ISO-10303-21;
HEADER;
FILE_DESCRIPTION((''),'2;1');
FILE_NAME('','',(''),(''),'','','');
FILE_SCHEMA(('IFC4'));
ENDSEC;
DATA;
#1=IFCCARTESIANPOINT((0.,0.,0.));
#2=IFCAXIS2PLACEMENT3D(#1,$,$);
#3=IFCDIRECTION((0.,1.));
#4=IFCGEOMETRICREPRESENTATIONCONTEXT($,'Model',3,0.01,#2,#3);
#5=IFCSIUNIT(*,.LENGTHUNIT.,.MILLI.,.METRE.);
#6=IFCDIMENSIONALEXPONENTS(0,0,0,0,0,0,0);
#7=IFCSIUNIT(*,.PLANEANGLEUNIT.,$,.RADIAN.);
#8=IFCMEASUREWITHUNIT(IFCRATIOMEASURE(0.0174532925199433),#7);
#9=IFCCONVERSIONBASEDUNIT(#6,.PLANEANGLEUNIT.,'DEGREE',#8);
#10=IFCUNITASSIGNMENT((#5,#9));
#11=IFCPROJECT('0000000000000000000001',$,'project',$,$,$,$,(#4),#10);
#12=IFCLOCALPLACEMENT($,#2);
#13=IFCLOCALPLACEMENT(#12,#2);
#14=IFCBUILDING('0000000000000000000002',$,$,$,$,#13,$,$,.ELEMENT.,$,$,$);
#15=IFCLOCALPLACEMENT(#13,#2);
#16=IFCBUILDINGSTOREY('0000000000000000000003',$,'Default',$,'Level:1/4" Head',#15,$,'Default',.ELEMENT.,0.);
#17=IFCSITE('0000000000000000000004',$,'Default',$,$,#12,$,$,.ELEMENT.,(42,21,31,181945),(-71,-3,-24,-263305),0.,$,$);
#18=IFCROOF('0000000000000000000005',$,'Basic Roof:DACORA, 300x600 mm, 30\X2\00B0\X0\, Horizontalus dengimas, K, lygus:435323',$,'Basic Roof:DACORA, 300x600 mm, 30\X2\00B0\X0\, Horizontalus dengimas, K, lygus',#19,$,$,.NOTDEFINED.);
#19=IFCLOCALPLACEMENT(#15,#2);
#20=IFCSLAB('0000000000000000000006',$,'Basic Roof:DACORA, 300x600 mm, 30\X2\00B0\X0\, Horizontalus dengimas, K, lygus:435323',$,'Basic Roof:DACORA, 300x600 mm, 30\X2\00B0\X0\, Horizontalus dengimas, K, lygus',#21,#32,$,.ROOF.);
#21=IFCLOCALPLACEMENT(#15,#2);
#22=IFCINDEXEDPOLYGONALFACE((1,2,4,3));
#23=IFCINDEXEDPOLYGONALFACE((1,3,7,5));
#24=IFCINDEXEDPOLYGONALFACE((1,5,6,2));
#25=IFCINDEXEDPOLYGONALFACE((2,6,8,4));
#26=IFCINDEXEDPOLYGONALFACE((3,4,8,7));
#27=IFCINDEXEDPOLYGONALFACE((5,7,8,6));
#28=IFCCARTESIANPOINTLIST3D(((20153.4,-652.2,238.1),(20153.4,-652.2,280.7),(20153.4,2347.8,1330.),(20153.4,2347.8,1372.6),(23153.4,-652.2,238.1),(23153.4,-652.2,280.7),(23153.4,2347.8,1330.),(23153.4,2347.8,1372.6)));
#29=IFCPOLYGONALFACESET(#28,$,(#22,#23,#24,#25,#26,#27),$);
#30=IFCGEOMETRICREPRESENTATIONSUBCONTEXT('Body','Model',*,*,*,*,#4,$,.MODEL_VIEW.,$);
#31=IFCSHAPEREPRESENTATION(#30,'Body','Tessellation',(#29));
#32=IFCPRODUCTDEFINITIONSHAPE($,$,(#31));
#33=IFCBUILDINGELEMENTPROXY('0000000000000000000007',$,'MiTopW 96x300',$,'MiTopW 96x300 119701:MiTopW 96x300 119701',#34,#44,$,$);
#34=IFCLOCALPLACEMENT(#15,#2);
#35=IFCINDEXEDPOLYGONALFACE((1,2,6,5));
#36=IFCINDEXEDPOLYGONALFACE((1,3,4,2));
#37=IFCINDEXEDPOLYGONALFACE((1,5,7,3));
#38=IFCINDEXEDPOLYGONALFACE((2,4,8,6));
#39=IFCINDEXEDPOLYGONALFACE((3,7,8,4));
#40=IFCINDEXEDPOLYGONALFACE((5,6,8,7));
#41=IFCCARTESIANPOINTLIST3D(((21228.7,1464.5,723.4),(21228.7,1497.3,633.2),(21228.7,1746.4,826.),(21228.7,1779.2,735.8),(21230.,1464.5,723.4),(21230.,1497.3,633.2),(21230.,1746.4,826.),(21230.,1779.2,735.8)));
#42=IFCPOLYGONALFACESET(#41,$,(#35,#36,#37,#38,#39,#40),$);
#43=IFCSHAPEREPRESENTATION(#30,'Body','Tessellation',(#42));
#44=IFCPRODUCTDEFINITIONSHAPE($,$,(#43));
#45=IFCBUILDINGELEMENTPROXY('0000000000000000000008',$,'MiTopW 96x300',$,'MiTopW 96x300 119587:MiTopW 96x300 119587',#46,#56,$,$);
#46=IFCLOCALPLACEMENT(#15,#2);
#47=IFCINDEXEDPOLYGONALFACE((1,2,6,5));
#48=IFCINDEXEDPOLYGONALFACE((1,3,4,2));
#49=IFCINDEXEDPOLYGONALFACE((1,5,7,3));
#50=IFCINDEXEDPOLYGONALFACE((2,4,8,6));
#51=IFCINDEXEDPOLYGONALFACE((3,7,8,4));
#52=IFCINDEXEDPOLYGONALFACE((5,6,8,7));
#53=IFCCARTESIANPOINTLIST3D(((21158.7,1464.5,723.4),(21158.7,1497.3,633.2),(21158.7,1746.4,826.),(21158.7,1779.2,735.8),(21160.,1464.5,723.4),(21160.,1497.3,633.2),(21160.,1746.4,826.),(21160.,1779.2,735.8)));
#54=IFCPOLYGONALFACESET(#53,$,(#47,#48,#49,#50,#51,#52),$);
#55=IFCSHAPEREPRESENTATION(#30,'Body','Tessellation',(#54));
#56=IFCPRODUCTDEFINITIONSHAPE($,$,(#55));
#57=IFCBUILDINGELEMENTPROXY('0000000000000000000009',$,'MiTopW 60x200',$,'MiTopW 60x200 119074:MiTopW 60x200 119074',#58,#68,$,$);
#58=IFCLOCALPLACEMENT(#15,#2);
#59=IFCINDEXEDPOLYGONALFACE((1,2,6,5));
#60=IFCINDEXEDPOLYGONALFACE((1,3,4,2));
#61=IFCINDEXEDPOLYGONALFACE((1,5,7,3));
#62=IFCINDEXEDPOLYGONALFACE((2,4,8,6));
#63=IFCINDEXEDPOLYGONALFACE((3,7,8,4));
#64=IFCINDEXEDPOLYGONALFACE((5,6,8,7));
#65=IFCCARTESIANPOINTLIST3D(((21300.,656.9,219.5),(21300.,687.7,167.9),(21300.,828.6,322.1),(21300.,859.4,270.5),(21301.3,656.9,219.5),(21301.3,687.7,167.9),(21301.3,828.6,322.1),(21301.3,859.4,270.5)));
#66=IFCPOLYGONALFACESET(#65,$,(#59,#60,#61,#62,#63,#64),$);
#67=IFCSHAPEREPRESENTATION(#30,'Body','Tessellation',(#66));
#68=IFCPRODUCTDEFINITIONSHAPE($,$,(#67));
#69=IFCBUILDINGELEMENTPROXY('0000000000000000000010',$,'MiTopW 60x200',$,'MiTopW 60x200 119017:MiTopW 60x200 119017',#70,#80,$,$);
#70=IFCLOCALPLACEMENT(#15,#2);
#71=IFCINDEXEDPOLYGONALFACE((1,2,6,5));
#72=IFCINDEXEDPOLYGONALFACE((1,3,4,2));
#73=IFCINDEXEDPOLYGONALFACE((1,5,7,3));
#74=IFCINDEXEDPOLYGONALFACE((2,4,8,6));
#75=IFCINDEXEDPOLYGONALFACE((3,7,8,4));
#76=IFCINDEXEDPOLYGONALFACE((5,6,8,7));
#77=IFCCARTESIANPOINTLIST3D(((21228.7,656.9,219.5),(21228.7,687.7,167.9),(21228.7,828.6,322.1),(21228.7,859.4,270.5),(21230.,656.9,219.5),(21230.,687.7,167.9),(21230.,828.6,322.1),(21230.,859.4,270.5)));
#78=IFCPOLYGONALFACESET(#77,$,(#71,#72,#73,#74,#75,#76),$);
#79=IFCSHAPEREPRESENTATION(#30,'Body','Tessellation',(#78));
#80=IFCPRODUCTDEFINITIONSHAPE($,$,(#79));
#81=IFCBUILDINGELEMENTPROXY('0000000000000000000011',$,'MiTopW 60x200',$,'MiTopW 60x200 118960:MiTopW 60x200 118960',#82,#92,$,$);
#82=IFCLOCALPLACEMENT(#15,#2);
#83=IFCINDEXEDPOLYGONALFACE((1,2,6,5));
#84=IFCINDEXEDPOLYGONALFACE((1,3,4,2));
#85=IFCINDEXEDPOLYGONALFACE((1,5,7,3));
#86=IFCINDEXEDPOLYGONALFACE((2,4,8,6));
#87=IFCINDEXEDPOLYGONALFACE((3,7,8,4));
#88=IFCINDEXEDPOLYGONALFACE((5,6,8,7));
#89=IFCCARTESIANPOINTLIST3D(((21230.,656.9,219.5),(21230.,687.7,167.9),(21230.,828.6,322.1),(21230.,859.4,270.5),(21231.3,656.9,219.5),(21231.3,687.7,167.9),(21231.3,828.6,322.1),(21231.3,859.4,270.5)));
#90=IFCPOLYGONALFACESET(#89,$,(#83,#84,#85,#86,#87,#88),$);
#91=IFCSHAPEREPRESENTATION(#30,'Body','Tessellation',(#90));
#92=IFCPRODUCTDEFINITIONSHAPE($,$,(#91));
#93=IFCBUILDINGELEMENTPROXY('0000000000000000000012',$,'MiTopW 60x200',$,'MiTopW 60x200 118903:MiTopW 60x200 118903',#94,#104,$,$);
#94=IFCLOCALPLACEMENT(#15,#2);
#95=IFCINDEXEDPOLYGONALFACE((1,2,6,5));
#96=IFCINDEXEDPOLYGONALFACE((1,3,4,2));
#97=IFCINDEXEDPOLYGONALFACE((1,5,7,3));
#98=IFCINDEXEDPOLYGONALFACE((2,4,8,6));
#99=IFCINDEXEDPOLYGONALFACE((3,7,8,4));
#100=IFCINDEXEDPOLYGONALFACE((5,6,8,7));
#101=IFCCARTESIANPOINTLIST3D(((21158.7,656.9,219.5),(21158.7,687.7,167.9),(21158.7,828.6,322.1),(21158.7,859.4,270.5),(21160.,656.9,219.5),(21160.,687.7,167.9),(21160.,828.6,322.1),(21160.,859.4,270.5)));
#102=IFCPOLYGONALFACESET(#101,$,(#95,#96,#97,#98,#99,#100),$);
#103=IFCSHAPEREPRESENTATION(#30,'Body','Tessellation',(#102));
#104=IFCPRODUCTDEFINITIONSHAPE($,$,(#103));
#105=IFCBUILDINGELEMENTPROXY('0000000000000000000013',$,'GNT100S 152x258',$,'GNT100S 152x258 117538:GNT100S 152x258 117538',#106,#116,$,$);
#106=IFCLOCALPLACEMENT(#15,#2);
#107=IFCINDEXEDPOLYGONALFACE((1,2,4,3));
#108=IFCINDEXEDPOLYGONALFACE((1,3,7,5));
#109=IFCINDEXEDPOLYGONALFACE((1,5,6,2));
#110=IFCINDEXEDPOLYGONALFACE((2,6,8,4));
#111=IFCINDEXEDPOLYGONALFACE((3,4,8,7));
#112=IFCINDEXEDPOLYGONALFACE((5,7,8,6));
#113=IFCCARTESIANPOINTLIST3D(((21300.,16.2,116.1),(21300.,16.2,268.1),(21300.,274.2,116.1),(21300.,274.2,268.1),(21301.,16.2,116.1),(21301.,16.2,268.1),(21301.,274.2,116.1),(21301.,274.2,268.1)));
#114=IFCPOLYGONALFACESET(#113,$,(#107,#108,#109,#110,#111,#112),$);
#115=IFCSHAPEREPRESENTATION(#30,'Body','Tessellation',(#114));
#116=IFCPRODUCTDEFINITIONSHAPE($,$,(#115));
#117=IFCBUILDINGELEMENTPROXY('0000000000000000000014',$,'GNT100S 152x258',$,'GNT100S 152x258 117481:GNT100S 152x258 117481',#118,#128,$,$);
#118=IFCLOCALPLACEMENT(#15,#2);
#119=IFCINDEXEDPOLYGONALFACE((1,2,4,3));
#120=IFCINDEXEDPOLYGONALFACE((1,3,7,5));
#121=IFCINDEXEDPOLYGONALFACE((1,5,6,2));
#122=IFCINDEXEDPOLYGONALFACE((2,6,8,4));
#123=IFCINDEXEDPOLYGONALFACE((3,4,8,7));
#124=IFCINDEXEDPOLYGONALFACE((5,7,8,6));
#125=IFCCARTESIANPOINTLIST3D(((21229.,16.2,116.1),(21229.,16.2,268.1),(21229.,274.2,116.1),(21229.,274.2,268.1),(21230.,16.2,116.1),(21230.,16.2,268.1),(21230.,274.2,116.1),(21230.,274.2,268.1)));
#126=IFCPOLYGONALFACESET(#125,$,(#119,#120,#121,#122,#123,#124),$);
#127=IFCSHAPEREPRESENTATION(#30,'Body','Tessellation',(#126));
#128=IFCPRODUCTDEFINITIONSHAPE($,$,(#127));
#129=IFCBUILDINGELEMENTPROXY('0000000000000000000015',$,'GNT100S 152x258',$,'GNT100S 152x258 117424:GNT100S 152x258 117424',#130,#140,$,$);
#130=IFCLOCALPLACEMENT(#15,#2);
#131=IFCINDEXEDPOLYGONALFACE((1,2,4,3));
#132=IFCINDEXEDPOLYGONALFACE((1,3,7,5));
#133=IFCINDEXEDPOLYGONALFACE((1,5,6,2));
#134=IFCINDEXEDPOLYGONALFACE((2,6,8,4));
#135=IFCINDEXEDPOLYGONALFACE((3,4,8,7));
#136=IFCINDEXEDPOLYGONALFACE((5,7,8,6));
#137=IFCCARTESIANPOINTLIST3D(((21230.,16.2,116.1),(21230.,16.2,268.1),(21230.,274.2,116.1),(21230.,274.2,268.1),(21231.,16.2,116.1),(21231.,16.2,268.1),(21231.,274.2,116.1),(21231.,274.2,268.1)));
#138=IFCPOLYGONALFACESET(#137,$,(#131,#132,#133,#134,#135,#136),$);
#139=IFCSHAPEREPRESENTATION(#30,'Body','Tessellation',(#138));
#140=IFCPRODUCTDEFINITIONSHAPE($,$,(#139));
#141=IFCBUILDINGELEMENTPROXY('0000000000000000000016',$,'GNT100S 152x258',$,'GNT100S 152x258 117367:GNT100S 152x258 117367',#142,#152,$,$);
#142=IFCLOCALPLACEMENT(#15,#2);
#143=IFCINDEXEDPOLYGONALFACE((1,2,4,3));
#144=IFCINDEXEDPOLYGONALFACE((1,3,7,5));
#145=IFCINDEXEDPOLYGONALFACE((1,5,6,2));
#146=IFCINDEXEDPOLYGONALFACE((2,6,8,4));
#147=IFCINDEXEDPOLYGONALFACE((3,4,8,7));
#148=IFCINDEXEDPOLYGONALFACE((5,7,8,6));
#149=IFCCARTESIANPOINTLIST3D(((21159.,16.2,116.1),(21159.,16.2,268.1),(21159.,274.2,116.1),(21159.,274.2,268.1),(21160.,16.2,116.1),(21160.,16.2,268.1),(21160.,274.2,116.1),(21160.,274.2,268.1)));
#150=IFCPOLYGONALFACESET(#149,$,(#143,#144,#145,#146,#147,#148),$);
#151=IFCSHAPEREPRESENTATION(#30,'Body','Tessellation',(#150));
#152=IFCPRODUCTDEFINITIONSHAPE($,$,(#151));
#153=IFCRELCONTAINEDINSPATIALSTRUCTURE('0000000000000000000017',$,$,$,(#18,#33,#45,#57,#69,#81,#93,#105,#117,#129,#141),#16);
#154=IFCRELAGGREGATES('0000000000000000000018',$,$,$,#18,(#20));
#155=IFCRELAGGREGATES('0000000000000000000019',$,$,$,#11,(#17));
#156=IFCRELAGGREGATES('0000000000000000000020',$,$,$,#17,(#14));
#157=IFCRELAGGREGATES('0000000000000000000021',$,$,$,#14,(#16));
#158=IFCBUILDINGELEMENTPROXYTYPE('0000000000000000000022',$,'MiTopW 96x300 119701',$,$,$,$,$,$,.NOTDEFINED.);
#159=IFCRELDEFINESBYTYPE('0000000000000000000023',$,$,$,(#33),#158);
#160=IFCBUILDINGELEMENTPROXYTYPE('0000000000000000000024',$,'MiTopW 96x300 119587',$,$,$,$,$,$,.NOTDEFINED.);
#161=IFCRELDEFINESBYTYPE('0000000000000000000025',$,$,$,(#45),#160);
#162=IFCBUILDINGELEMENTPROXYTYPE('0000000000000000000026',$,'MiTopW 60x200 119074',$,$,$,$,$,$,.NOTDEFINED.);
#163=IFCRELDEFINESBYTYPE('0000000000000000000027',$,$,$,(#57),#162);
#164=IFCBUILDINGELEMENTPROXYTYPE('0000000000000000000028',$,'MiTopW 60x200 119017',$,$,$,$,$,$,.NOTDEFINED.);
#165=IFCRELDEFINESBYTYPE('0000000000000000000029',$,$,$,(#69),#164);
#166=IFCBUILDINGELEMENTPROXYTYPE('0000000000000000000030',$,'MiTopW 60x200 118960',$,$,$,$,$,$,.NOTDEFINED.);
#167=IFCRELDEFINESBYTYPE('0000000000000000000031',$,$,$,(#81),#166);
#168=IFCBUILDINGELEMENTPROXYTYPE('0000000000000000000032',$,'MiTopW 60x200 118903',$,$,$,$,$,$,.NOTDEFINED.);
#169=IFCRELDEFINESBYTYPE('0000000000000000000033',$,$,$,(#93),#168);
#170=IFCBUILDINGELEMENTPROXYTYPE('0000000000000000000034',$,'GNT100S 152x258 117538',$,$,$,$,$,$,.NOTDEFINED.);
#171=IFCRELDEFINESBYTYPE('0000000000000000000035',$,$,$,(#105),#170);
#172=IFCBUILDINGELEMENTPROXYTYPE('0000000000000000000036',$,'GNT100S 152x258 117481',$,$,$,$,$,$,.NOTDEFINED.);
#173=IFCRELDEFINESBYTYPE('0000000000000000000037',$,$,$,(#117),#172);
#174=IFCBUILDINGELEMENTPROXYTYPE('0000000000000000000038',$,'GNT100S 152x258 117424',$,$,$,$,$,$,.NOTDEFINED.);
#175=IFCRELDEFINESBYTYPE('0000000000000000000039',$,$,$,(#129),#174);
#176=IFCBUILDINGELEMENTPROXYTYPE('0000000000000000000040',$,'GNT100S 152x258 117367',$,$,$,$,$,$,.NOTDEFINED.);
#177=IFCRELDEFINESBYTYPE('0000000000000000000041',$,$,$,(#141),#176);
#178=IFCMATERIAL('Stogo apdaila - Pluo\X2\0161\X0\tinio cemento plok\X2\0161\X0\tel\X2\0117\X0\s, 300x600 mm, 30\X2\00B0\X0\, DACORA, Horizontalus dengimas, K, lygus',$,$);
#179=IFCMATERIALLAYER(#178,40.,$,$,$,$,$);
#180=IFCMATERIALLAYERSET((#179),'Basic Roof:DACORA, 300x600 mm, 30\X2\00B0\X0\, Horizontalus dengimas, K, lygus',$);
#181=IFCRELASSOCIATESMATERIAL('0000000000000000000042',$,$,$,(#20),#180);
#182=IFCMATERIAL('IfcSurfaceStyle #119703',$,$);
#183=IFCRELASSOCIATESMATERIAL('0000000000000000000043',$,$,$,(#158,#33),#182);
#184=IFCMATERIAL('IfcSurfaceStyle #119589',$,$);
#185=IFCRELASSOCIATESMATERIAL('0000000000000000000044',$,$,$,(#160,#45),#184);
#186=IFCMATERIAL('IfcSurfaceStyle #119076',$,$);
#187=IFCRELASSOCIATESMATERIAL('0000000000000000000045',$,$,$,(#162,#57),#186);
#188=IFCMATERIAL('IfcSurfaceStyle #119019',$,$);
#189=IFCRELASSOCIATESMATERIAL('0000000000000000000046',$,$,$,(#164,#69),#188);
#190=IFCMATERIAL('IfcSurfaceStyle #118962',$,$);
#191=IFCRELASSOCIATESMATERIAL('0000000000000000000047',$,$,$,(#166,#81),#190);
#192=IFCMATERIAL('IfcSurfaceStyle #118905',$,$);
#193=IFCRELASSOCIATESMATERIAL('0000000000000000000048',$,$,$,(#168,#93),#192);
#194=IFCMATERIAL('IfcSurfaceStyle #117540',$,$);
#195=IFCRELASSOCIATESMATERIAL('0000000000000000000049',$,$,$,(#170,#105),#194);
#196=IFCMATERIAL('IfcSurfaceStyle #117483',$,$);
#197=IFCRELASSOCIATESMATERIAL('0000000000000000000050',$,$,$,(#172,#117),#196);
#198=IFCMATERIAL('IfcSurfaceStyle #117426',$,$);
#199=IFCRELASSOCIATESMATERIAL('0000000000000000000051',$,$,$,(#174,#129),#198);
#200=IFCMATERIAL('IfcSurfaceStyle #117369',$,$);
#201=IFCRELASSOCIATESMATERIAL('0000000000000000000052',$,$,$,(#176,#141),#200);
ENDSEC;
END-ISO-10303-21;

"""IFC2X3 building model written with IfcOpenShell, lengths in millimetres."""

from ifc_helpers import new_model, entity, si_unit, converted_unit, direction, frame, frame_2d, origin, origin_2d_with_axis, place, context, subcontext, project, spatial, polyline, rectangle, outline, extrude, source, transform, mapped, material, layer, layer_set, type_object, type_shapes, element, aggregate, save


model = new_model("IFC2X3")

# Units and contexts
model_context = context("Model", 3, precision=0.01, world=origin(), true_north=direction((0.0, 1.0)))
body_context = subcontext(model_context, "Body", "Model", "MODEL_VIEW")
ifc_project = project(units=[si_unit("LENGTHUNIT", "METRE", prefix="MILLI"), converted_unit("PLANEANGLEUNIT", "DEGREE", entity("IfcRatioMeasure", 0.0174532925199433), si_unit("PLANEANGLEUNIT", "RADIAN"), dimensions=[0, 0, 0, 0, 0, 0, 0])], contexts=[model_context])

# Site, building, storey
site_placement = place(None, origin())
site = spatial("IfcSite", under=ifc_project, at=site_placement, Name="Default", CompositionType="ELEMENT", RefLatitude=(42, 21, 31, 181945), RefLongitude=(-71, -3, -24, -263305), RefElevation=0.0)
building_placement = place(site_placement, origin())
building = spatial("IfcBuilding", under=site, at=building_placement, CompositionType="ELEMENT")
storey_placement = place(building_placement, origin())
storey = spatial("IfcBuildingStorey", under=building, at=storey_placement, Name="Default", ObjectType="Level:1/4\" Head", LongName="Default", CompositionType="ELEMENT", Elevation=0.0)

# Roof, slab
roof_placement = place(storey_placement, frame((20153.4, -652.2, 238.1)))
roof = element("IfcRoof", 1, at=roof_placement, inside=storey, Name="Basic Roof:DACORA, 300x600 mm, 30°, Horizontalus dengimas, K, lygus:435323", ObjectType="Basic Roof:DACORA, 300x600 mm, 30°, Horizontalus dengimas, K, lygus", ShapeType="NOTDEFINED")
ifc_material_1 = material(Name="Stogo apdaila - Pluoštinio cemento plokštelės, 300x600 mm, 30°, DACORA, Horizontalus dengimas, K, lygus")
ifc_layer = layer(ifc_material_1, 40.0)
ifc_layer_set = layer_set([ifc_layer], Name="Basic Roof:DACORA, 300x600 mm, 30°, Horizontalus dengimas, K, lygus")
slab_placement = place(roof_placement, origin())
slab = element("IfcSlab", 2, at=slab_placement, material=ifc_layer_set, Name="Basic Roof:DACORA, 300x600 mm, 30°, Horizontalus dengimas, K, lygus:435323", ObjectType="Basic Roof:DACORA, 300x600 mm, 30°, Horizontalus dengimas, K, lygus", PredefinedType="ROOF", context=body_context, shape_type="SweptSolid", body=[
    extrude(rectangle(XDim=3192.5, YDim=3000.0, at=frame_2d((0.0, 0.0), x_axis=(0.0, -1.0))), frame((1500.0, 1500.0, 546.0), z_axis=(0.0, -0.34202, 0.939693), x_axis=(1.0, 0.0, 0.0)), (0.0, 0.34202, 0.939693), 42.6),
])
aggregate(roof, [slab])

# Building element proxies
ifc_material_2 = material(Name="IfcSurfaceStyle #119703")
building_element_proxy_type_1 = type_object("IfcBuildingElementProxyType", Name="MiTopW 96x300 119701", PredefinedType="NOTDEFINED", material=ifc_material_2)
shared_shape_1 = source(origin(), body_context, "Body", "SweptSolid", [
    extrude(outline(polyline([(-150.0, -48.0), (150.0, -48.0), (150.0, 48.0), (-150.0, 48.0), (-150.0, -48.0)])), frame((150.0, 48.0, 0.0), z_axis=(0.0, 0.0, 1.0), x_axis=(-1.0, 0.0, 0.0)), (0.0, 0.0, 1.0), 1.3),
])
type_shapes(building_element_proxy_type_1, [shared_shape_1])
proxy_1_placement = place(building_placement, frame((21230.0, 1464.5, 723.4), z_axis=(-1.0, 0.0, 0.0), x_axis=(0.0, 0.939693, 0.34202)))
element("IfcBuildingElementProxy", 3, at=proxy_1_placement, inside=storey, type_object=building_element_proxy_type_1, material=ifc_material_2, Name="MiTopW 96x300", ObjectType="MiTopW 96x300 119701:MiTopW 96x300 119701", context=body_context, shape_type="MappedRepresentation", body=[
    mapped(shared_shape_1, transform((0.0, 0.0, 0.0), scale=1.0)),
])
ifc_material_3 = material(Name="IfcSurfaceStyle #119589")
building_element_proxy_type_2 = type_object("IfcBuildingElementProxyType", Name="MiTopW 96x300 119587", PredefinedType="NOTDEFINED", material=ifc_material_3)
shared_shape_2 = source(origin(), body_context, "Body", "SweptSolid", [
    extrude(outline(polyline([(-150.0, -48.0), (150.0, -48.0), (150.0, 48.0), (-150.0, 48.0), (-150.0, -48.0)])), frame((150.0, 48.0, 0.0), z_axis=(0.0, 0.0, 1.0), x_axis=(-1.0, 0.0, 0.0)), (0.0, 0.0, 1.0), 1.3),
])
type_shapes(building_element_proxy_type_2, [shared_shape_2])
proxy_2_placement = place(building_placement, frame((21160.0, 1464.5, 723.4), z_axis=(-1.0, 0.0, 0.0), x_axis=(0.0, 0.939693, 0.34202)))
element("IfcBuildingElementProxy", 4, at=proxy_2_placement, inside=storey, type_object=building_element_proxy_type_2, material=ifc_material_3, Name="MiTopW 96x300", ObjectType="MiTopW 96x300 119587:MiTopW 96x300 119587", context=body_context, shape_type="MappedRepresentation", body=[
    mapped(shared_shape_2, transform((0.0, 0.0, 0.0), scale=1.0)),
])
ifc_material_4 = material(Name="IfcSurfaceStyle #119076")
building_element_proxy_type_3 = type_object("IfcBuildingElementProxyType", Name="MiTopW 60x200 119074", PredefinedType="NOTDEFINED", material=ifc_material_4)
shared_shape_3 = source(origin(), body_context, "Body", "SweptSolid", [
    extrude(outline(polyline([(-100.0, -30.0), (100.0, -30.0), (100.0, 30.0), (-100.0, 30.0), (-100.0, -30.0)])), frame((100.0, 30.0, 0.0), z_axis=(0.0, 0.0, 1.0), x_axis=(-1.0, 0.0, 0.0)), (0.0, 0.0, 1.0), 1.3),
])
type_shapes(building_element_proxy_type_3, [shared_shape_3])
proxy_3_placement = place(building_placement, frame((21301.3, 656.9, 219.5), z_axis=(-1.0, 0.0, 0.0), x_axis=(0.0, 0.858392, 0.512994)))
element("IfcBuildingElementProxy", 5, at=proxy_3_placement, inside=storey, type_object=building_element_proxy_type_3, material=ifc_material_4, Name="MiTopW 60x200", ObjectType="MiTopW 60x200 119074:MiTopW 60x200 119074", context=body_context, shape_type="MappedRepresentation", body=[
    mapped(shared_shape_3, transform((0.0, 0.0, 0.0), scale=1.0)),
])
ifc_material_5 = material(Name="IfcSurfaceStyle #119019")
building_element_proxy_type_4 = type_object("IfcBuildingElementProxyType", Name="MiTopW 60x200 119017", PredefinedType="NOTDEFINED", material=ifc_material_5)
shared_shape_4 = source(origin(), body_context, "Body", "SweptSolid", [
    extrude(outline(polyline([(-100.0, -30.0), (100.0, -30.0), (100.0, 30.0), (-100.0, 30.0), (-100.0, -30.0)])), frame((100.0, 30.0, 0.0), z_axis=(0.0, 0.0, 1.0), x_axis=(-1.0, 0.0, 0.0)), (0.0, 0.0, 1.0), 1.3),
])
type_shapes(building_element_proxy_type_4, [shared_shape_4])
proxy_4_placement = place(building_placement, frame((21230.0, 656.9, 219.5), z_axis=(-1.0, 0.0, 0.0), x_axis=(0.0, 0.858392, 0.512994)))
element("IfcBuildingElementProxy", 6, at=proxy_4_placement, inside=storey, type_object=building_element_proxy_type_4, material=ifc_material_5, Name="MiTopW 60x200", ObjectType="MiTopW 60x200 119017:MiTopW 60x200 119017", context=body_context, shape_type="MappedRepresentation", body=[
    mapped(shared_shape_4, transform((0.0, 0.0, 0.0), scale=1.0)),
])
ifc_material_6 = material(Name="IfcSurfaceStyle #118962")
building_element_proxy_type_5 = type_object("IfcBuildingElementProxyType", Name="MiTopW 60x200 118960", PredefinedType="NOTDEFINED", material=ifc_material_6)
shared_shape_5 = source(origin(), body_context, "Body", "SweptSolid", [
    extrude(outline(polyline([(-100.0, -30.0), (100.0, -30.0), (100.0, 30.0), (-100.0, 30.0), (-100.0, -30.0)])), frame((100.0, 30.0, 0.0), z_axis=(0.0, 0.0, 1.0), x_axis=(-1.0, 0.0, 0.0)), (0.0, 0.0, 1.0), 1.3),
])
type_shapes(building_element_proxy_type_5, [shared_shape_5])
proxy_5_placement = place(building_placement, frame((21231.3, 656.9, 219.5), z_axis=(-1.0, 0.0, 0.0), x_axis=(0.0, 0.858392, 0.512994)))
element("IfcBuildingElementProxy", 7, at=proxy_5_placement, inside=storey, type_object=building_element_proxy_type_5, material=ifc_material_6, Name="MiTopW 60x200", ObjectType="MiTopW 60x200 118960:MiTopW 60x200 118960", context=body_context, shape_type="MappedRepresentation", body=[
    mapped(shared_shape_5, transform((0.0, 0.0, 0.0), scale=1.0)),
])
ifc_material_7 = material(Name="IfcSurfaceStyle #118905")
building_element_proxy_type_6 = type_object("IfcBuildingElementProxyType", Name="MiTopW 60x200 118903", PredefinedType="NOTDEFINED", material=ifc_material_7)
shared_shape_6 = source(origin(), body_context, "Body", "SweptSolid", [
    extrude(outline(polyline([(-100.0, -30.0), (100.0, -30.0), (100.0, 30.0), (-100.0, 30.0), (-100.0, -30.0)])), frame((100.0, 30.0, 0.0), z_axis=(0.0, 0.0, 1.0), x_axis=(-1.0, 0.0, 0.0)), (0.0, 0.0, 1.0), 1.3),
])
type_shapes(building_element_proxy_type_6, [shared_shape_6])
proxy_6_placement = place(building_placement, frame((21160.0, 656.9, 219.5), z_axis=(-1.0, 0.0, 0.0), x_axis=(0.0, 0.858392, 0.512994)))
element("IfcBuildingElementProxy", 8, at=proxy_6_placement, inside=storey, type_object=building_element_proxy_type_6, material=ifc_material_7, Name="MiTopW 60x200", ObjectType="MiTopW 60x200 118903:MiTopW 60x200 118903", context=body_context, shape_type="MappedRepresentation", body=[
    mapped(shared_shape_6, transform((0.0, 0.0, 0.0), scale=1.0)),
])
ifc_material_8 = material(Name="IfcSurfaceStyle #117540")
building_element_proxy_type_7 = type_object("IfcBuildingElementProxyType", Name="GNT100S 152x258 117538", PredefinedType="NOTDEFINED", material=ifc_material_8)
shared_shape_7 = source(origin(), body_context, "Body", "SweptSolid", [
    extrude(rectangle(XDim=258.0, YDim=152.0, at=origin_2d_with_axis()), frame((129.0, 76.0, 0.0), z_axis=(0.0, 0.0, 1.0), x_axis=(-1.0, 0.0, 0.0)), (0.0, 0.0, 1.0), 1.0),
])
type_shapes(building_element_proxy_type_7, [shared_shape_7])
proxy_7_placement = place(building_placement, frame((21301.0, 16.2, 268.1), z_axis=(-1.0, 0.0, 0.0), x_axis=(0.0, 1.0, 0.0)))
element("IfcBuildingElementProxy", 9, at=proxy_7_placement, inside=storey, type_object=building_element_proxy_type_7, material=ifc_material_8, Name="GNT100S 152x258", ObjectType="GNT100S 152x258 117538:GNT100S 152x258 117538", context=body_context, shape_type="MappedRepresentation", body=[
    mapped(shared_shape_7, transform((0.0, 0.0, 0.0), scale=1.0)),
])
ifc_material_9 = material(Name="IfcSurfaceStyle #117483")
building_element_proxy_type_8 = type_object("IfcBuildingElementProxyType", Name="GNT100S 152x258 117481", PredefinedType="NOTDEFINED", material=ifc_material_9)
shared_shape_8 = source(origin(), body_context, "Body", "SweptSolid", [
    extrude(rectangle(XDim=258.0, YDim=152.0, at=origin_2d_with_axis()), frame((129.0, 76.0, 0.0), z_axis=(0.0, 0.0, 1.0), x_axis=(-1.0, 0.0, 0.0)), (0.0, 0.0, 1.0), 1.0),
])
type_shapes(building_element_proxy_type_8, [shared_shape_8])
proxy_8_placement = place(building_placement, frame((21230.0, 16.2, 268.1), z_axis=(-1.0, 0.0, 0.0), x_axis=(0.0, 1.0, 0.0)))
element("IfcBuildingElementProxy", 10, at=proxy_8_placement, inside=storey, type_object=building_element_proxy_type_8, material=ifc_material_9, Name="GNT100S 152x258", ObjectType="GNT100S 152x258 117481:GNT100S 152x258 117481", context=body_context, shape_type="MappedRepresentation", body=[
    mapped(shared_shape_8, transform((0.0, 0.0, 0.0), scale=1.0)),
])
ifc_material_10 = material(Name="IfcSurfaceStyle #117426")
building_element_proxy_type_9 = type_object("IfcBuildingElementProxyType", Name="GNT100S 152x258 117424", PredefinedType="NOTDEFINED", material=ifc_material_10)
shared_shape_9 = source(origin(), body_context, "Body", "SweptSolid", [
    extrude(rectangle(XDim=258.0, YDim=152.0, at=origin_2d_with_axis()), frame((129.0, 76.0, 0.0), z_axis=(0.0, 0.0, 1.0), x_axis=(-1.0, 0.0, 0.0)), (0.0, 0.0, 1.0), 1.0),
])
type_shapes(building_element_proxy_type_9, [shared_shape_9])
proxy_9_placement = place(building_placement, frame((21231.0, 16.2, 268.1), z_axis=(-1.0, 0.0, 0.0), x_axis=(0.0, 1.0, 0.0)))
element("IfcBuildingElementProxy", 11, at=proxy_9_placement, inside=storey, type_object=building_element_proxy_type_9, material=ifc_material_10, Name="GNT100S 152x258", ObjectType="GNT100S 152x258 117424:GNT100S 152x258 117424", context=body_context, shape_type="MappedRepresentation", body=[
    mapped(shared_shape_9, transform((0.0, 0.0, 0.0), scale=1.0)),
])
ifc_material_11 = material(Name="IfcSurfaceStyle #117369")
building_element_proxy_type_10 = type_object("IfcBuildingElementProxyType", Name="GNT100S 152x258 117367", PredefinedType="NOTDEFINED", material=ifc_material_11)
shared_shape_10 = source(origin(), body_context, "Body", "SweptSolid", [
    extrude(rectangle(XDim=258.0, YDim=152.0, at=origin_2d_with_axis()), frame((129.0, 76.0, 0.0), z_axis=(0.0, 0.0, 1.0), x_axis=(-1.0, 0.0, 0.0)), (0.0, 0.0, 1.0), 1.0),
])
type_shapes(building_element_proxy_type_10, [shared_shape_10])
proxy_10_placement = place(building_placement, frame((21160.0, 16.2, 268.1), z_axis=(-1.0, 0.0, 0.0), x_axis=(0.0, 1.0, 0.0)))
element("IfcBuildingElementProxy", 12, at=proxy_10_placement, inside=storey, type_object=building_element_proxy_type_10, material=ifc_material_11, Name="GNT100S 152x258", ObjectType="GNT100S 152x258 117367:GNT100S 152x258 117367", context=body_context, shape_type="MappedRepresentation", body=[
    mapped(shared_shape_10, transform((0.0, 0.0, 0.0), scale=1.0)),
])

save(model, "model.ifc")
